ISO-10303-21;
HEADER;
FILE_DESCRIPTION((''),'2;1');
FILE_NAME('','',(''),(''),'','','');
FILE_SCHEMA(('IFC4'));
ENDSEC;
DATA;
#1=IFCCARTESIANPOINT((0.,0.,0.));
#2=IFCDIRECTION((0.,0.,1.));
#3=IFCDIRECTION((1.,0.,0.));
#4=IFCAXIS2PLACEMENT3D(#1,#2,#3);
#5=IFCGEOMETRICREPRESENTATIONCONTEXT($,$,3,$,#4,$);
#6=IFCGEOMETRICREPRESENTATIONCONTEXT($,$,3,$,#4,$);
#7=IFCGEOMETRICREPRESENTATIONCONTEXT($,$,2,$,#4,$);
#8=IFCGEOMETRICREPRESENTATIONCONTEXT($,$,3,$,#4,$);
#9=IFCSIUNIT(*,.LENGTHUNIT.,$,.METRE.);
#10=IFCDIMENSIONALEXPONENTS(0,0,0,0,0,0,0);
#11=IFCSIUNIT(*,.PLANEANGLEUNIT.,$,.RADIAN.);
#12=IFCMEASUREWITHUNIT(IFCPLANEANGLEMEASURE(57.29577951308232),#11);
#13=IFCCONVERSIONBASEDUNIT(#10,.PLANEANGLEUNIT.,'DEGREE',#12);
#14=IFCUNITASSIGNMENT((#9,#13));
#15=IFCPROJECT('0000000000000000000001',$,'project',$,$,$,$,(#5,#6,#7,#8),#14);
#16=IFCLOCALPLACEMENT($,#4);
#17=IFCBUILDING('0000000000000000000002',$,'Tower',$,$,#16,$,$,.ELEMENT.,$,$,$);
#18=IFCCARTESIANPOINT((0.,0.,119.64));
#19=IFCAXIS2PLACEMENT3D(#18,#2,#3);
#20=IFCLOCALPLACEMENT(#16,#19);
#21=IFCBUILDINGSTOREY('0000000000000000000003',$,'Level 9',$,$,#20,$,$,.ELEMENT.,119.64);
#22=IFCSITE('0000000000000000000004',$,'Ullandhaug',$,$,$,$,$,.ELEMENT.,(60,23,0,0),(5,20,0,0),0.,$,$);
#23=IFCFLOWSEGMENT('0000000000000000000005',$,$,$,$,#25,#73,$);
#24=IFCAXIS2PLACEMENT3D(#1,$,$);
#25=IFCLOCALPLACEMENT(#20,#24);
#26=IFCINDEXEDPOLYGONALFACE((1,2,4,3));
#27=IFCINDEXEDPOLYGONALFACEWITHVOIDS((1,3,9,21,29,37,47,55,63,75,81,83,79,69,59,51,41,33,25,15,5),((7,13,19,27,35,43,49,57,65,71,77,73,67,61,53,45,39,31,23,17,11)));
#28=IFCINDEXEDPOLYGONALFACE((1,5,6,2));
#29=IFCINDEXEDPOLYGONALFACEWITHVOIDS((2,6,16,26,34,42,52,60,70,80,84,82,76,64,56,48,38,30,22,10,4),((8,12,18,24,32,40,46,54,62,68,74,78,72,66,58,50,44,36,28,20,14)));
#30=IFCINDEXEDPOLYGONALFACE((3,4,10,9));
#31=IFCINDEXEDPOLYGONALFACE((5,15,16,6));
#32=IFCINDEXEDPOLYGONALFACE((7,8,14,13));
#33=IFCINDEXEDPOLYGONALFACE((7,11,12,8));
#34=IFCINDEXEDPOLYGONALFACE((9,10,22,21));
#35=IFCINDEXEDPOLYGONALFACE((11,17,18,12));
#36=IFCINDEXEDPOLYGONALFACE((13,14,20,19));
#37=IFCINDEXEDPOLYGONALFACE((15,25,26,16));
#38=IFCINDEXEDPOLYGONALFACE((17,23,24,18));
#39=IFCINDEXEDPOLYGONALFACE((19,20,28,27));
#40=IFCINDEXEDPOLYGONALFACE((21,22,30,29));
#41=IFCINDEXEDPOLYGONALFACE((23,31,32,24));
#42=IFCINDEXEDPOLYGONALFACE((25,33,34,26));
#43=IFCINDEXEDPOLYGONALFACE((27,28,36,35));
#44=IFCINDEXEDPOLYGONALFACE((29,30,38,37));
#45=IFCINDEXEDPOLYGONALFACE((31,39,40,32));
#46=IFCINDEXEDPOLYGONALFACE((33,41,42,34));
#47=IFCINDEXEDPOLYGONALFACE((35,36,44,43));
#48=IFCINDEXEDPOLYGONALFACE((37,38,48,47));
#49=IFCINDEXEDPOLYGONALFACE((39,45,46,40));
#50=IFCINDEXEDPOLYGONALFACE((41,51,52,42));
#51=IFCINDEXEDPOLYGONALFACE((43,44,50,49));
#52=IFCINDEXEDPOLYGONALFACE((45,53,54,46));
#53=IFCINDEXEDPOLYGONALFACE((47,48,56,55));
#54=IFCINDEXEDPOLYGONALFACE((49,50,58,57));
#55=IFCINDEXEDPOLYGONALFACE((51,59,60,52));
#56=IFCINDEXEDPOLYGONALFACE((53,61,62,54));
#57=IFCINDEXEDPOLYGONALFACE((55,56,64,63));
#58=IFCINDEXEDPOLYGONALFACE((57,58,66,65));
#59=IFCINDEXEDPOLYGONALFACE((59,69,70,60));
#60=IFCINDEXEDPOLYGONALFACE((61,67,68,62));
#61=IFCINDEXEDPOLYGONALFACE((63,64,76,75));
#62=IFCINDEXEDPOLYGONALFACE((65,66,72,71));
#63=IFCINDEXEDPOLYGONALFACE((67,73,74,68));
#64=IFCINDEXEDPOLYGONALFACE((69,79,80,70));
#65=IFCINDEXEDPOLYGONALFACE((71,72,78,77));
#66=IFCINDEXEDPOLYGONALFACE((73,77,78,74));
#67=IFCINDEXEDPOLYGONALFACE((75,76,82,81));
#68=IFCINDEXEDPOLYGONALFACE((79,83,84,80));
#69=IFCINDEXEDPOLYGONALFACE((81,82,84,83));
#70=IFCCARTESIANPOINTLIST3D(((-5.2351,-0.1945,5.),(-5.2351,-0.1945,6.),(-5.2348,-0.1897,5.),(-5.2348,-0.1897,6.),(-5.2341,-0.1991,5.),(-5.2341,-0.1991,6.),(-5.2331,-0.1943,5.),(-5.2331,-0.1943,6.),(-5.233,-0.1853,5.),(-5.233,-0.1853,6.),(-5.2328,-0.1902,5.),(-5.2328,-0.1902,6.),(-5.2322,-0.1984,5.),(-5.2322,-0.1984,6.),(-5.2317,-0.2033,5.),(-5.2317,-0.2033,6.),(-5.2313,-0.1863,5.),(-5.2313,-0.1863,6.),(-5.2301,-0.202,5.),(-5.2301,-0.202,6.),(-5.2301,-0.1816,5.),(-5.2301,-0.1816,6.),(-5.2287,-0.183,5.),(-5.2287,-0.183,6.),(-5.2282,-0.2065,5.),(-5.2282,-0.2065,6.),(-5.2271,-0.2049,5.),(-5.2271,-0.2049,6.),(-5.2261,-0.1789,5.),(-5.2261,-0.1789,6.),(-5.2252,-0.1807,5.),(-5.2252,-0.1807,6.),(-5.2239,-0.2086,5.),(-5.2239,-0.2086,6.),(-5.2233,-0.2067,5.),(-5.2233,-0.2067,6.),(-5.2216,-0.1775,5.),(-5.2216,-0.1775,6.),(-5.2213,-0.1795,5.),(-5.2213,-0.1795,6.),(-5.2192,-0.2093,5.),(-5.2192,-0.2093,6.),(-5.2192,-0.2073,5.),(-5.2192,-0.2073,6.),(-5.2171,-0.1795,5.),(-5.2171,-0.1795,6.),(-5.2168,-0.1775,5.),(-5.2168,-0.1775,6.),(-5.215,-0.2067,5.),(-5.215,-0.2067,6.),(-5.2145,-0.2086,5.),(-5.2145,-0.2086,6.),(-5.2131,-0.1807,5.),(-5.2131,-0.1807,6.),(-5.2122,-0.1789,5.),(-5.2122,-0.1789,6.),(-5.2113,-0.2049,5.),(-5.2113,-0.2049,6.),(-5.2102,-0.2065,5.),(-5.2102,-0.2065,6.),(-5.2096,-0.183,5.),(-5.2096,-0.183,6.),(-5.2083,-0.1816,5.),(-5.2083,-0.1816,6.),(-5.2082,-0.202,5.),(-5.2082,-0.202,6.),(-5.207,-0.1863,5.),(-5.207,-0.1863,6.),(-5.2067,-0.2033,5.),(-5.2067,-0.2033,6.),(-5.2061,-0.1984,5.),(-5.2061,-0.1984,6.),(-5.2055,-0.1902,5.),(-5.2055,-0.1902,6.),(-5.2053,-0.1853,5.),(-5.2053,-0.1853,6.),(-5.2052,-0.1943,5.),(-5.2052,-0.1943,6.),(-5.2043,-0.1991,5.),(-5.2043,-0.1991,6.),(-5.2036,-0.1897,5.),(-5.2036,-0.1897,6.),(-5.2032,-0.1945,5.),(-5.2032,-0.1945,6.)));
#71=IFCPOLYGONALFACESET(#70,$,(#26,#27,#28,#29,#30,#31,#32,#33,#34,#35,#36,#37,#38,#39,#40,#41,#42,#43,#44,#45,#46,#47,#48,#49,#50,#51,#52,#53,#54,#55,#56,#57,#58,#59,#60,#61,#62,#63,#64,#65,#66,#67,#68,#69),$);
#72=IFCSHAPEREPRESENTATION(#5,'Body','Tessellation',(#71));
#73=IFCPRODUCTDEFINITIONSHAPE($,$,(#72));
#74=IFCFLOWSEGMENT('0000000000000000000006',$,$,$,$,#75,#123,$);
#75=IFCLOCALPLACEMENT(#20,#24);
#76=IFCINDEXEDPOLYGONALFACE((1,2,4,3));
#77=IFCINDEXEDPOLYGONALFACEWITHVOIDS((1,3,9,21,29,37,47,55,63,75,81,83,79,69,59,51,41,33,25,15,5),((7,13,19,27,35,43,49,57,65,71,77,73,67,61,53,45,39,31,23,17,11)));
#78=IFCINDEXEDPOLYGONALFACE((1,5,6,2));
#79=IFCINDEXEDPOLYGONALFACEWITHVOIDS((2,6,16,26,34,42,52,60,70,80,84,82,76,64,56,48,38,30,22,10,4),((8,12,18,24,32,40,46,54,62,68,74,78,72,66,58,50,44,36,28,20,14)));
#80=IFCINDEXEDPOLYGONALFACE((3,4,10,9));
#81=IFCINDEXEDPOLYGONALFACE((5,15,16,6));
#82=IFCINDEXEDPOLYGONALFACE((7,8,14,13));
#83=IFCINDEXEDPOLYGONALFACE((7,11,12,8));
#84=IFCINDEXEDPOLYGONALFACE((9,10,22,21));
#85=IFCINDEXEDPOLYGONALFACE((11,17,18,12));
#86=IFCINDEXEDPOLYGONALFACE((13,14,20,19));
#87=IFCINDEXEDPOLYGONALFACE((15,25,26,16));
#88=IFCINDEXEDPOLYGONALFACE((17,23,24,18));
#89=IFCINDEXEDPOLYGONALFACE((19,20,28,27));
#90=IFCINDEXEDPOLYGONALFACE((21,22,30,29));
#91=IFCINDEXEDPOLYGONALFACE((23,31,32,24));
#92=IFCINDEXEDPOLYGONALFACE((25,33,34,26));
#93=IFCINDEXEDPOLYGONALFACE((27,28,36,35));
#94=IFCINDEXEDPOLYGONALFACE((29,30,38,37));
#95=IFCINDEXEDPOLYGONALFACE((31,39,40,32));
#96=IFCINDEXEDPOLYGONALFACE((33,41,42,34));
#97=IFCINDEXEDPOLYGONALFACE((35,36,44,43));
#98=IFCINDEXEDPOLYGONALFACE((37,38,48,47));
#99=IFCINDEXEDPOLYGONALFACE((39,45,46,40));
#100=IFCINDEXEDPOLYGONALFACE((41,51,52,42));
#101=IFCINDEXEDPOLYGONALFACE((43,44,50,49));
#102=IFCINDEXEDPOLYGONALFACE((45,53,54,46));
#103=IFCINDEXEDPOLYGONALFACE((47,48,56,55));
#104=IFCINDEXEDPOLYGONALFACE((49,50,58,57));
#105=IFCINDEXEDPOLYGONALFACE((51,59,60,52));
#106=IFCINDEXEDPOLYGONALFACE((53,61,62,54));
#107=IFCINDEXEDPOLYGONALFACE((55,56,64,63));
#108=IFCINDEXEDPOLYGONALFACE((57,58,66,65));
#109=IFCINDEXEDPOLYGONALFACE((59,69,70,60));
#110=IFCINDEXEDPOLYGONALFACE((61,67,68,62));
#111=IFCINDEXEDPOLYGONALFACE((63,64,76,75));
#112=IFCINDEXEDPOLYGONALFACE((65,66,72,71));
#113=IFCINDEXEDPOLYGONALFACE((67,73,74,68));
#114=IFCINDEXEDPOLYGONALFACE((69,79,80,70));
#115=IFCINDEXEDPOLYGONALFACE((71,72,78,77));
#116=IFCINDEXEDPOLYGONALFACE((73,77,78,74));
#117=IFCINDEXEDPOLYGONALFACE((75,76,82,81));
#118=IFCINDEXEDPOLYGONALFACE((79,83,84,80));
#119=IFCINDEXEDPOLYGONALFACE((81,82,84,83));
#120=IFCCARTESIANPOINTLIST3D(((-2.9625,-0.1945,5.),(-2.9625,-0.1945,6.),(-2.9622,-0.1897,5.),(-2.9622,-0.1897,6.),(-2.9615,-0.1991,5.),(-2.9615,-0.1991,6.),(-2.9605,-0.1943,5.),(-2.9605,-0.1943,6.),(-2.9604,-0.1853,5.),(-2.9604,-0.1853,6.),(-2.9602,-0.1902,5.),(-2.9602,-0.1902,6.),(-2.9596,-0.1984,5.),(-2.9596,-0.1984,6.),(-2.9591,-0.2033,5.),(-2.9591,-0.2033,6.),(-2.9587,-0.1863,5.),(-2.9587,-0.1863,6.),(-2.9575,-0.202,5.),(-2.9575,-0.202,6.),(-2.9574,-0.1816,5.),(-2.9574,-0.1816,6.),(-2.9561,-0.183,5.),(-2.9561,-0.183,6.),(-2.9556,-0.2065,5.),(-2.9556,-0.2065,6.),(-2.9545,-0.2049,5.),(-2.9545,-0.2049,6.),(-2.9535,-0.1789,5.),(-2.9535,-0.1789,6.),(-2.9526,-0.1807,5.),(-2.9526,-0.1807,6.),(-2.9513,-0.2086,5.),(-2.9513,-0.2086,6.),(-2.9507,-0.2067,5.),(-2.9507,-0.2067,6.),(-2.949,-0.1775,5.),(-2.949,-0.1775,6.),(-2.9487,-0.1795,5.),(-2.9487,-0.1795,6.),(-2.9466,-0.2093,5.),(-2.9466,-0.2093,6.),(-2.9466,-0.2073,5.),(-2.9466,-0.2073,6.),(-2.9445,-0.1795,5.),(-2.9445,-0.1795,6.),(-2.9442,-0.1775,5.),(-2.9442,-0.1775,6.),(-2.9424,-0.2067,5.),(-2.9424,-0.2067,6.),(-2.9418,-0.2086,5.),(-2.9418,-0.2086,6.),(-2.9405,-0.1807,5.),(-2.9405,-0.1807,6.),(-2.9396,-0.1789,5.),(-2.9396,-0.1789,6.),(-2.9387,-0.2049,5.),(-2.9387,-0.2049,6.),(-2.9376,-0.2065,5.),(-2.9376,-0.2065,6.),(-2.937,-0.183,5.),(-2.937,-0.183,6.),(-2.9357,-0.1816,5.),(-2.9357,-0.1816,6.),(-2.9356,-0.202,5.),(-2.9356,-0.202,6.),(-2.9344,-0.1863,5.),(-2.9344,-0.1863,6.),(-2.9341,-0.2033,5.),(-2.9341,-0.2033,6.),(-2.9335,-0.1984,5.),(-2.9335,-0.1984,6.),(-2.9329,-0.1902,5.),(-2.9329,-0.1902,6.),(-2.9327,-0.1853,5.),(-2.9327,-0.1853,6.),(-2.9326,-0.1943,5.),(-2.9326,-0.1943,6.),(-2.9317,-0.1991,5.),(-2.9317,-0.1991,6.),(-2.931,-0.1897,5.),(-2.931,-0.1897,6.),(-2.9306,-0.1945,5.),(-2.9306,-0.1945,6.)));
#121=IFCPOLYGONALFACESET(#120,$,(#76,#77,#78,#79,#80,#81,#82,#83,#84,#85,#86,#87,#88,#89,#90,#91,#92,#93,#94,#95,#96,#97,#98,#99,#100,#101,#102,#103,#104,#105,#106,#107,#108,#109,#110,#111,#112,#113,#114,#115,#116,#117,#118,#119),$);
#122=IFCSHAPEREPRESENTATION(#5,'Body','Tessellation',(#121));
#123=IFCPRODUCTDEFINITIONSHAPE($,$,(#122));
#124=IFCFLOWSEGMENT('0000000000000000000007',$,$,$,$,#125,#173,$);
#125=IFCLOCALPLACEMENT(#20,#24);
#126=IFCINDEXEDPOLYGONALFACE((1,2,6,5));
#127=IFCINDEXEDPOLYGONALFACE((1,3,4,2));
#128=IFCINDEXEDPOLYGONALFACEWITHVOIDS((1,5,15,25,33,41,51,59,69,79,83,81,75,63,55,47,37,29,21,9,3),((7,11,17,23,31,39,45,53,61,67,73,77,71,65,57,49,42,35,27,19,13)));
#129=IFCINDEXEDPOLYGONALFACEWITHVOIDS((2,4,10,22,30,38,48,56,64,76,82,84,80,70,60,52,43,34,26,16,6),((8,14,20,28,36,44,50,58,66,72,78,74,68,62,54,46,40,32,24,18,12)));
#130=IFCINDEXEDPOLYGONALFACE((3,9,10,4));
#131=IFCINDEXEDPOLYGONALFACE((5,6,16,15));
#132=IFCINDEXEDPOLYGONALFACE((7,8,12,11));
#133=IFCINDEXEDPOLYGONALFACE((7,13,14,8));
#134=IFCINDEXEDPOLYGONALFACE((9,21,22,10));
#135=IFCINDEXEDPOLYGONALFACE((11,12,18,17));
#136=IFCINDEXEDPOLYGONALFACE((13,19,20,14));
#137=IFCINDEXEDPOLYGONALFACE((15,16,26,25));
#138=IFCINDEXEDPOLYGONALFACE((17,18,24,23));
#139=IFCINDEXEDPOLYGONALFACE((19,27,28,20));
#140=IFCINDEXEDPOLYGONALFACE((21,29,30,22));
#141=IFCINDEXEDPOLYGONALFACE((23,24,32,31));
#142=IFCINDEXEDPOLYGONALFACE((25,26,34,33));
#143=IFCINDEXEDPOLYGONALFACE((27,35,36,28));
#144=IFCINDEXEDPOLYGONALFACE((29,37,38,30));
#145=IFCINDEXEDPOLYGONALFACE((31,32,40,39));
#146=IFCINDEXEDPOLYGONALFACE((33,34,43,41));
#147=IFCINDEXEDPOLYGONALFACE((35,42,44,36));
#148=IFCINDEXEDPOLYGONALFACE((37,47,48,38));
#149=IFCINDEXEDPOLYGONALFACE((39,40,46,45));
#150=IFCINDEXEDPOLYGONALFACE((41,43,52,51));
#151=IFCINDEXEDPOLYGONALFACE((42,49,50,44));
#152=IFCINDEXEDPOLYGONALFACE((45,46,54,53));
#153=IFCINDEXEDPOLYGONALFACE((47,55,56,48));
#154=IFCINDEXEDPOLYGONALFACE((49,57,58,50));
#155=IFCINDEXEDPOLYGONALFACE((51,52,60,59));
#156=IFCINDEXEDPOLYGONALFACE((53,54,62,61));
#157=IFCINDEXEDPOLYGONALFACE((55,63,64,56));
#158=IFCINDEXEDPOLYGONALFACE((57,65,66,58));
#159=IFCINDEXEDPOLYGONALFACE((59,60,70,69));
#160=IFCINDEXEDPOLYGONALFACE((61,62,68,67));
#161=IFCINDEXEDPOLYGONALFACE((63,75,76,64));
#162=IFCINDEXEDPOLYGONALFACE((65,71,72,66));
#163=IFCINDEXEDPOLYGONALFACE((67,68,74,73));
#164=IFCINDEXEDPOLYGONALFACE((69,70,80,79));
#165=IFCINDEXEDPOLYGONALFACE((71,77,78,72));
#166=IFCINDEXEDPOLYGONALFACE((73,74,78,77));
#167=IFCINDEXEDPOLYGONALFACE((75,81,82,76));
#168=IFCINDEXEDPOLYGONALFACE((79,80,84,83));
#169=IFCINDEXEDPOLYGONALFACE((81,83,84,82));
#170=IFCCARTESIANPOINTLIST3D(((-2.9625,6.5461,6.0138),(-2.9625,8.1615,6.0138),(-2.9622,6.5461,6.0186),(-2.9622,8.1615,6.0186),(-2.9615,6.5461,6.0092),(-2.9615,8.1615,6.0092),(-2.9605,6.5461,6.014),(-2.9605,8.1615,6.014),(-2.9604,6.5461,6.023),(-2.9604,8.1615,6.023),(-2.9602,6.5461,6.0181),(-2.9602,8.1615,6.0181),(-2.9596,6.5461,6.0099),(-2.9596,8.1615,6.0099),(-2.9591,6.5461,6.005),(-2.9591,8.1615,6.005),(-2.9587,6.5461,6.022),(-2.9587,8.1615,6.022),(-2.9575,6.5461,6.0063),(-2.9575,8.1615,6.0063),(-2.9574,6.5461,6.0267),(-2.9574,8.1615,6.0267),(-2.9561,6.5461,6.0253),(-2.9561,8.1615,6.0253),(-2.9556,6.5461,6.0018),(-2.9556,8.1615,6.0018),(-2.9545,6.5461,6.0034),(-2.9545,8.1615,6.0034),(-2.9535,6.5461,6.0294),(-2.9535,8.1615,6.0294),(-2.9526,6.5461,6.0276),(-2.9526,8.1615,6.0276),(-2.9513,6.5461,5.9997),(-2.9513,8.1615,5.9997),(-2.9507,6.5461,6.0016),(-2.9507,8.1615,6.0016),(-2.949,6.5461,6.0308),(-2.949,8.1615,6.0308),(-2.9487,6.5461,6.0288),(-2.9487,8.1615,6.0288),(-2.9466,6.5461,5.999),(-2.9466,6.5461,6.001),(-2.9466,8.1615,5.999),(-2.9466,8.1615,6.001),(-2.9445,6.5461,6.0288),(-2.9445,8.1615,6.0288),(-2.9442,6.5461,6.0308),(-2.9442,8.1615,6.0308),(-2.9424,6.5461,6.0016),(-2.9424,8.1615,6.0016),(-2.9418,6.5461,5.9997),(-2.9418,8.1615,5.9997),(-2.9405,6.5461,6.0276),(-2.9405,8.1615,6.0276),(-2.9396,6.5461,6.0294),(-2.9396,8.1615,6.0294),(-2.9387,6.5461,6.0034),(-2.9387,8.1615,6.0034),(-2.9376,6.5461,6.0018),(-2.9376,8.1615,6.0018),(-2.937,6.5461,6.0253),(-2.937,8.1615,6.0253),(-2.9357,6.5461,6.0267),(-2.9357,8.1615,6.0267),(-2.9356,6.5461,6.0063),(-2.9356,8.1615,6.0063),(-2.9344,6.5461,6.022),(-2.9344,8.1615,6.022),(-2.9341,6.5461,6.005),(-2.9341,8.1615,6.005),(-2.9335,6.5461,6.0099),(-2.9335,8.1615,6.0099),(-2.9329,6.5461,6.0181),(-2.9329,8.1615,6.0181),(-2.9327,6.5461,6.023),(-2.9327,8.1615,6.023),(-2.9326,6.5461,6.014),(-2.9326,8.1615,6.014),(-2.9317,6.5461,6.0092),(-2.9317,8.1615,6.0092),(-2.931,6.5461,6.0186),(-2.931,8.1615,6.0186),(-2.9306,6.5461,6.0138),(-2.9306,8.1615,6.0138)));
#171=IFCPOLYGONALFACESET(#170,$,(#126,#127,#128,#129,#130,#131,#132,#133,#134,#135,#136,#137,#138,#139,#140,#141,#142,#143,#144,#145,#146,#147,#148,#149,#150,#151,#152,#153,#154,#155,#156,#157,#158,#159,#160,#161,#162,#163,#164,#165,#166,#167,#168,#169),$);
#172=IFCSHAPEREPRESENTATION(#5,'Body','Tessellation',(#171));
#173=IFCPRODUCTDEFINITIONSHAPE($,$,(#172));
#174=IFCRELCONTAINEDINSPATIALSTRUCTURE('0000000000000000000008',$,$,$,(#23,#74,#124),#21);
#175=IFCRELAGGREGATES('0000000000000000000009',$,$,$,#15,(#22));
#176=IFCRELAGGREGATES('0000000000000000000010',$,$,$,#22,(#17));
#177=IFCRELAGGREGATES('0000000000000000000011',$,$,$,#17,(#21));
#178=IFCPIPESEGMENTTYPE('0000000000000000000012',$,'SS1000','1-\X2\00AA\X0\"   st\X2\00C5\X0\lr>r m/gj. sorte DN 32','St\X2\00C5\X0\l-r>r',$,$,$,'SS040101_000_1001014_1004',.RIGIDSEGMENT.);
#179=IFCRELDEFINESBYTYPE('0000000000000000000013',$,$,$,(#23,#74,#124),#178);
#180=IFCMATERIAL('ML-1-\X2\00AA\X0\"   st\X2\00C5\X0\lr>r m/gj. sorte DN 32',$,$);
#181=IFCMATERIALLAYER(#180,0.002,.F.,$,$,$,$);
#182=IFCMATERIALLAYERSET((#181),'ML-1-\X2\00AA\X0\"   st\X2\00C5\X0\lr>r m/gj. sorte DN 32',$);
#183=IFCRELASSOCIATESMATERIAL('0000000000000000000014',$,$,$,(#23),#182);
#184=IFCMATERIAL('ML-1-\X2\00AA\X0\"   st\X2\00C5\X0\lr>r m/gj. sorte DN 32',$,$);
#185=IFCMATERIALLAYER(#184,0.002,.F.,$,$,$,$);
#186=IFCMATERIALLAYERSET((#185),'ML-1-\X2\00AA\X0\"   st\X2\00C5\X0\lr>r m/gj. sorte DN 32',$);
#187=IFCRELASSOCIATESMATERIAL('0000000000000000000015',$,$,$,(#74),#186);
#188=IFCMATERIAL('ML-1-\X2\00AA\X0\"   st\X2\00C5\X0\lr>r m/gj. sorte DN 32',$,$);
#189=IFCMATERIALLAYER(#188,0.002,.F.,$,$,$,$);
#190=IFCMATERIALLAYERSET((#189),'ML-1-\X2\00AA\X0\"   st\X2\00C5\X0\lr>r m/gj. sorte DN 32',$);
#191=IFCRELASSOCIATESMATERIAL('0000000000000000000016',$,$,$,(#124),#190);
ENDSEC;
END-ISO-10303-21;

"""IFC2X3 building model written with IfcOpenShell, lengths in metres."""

from ifc_helpers import new_model, entity, si_unit, converted_unit, frame, origin_with_axes, origin_2d_with_axis, place, context, project, spatial, hollow_circle, extrude, material, layer, layer_set, layer_usage, type_object, element, save


model = new_model("IFC2X3")

# Units and contexts
context_of_model_1 = context(None, 3, world=origin_with_axes())
context_of_model_2 = context(None, 3, world=origin_with_axes())
context_of_model_3 = context(None, 2, world=origin_with_axes())
context_of_model_4 = context(None, 3, world=origin_with_axes())
ifc_project = project(units=[si_unit("LENGTHUNIT", "METRE"), converted_unit("PLANEANGLEUNIT", "DEGREE", entity("IfcPlaneAngleMeasure", 57.29577951308232), si_unit("PLANEANGLEUNIT", "RADIAN"), dimensions=[0, 0, 0, 0, 0, 0, 0])], contexts=[context_of_model_1, context_of_model_2, context_of_model_3, context_of_model_4])

# Site, building, storey
site = spatial("IfcSite", under=ifc_project, Name="Ullandhaug", CompositionType="ELEMENT", RefLatitude=(60, 23, 0, 0), RefLongitude=(5, 20, 0, 0), RefElevation=0.0)
building_placement = place(None, origin_with_axes())
building = spatial("IfcBuilding", under=site, at=building_placement, Name="Tower", CompositionType="ELEMENT")
storey_placement = place(building_placement, frame((0.0, 0.0, 119.64), z_axis=(0.0, 0.0, 1.0), x_axis=(1.0, 0.0, 0.0)))
storey = spatial("IfcBuildingStorey", under=building, at=storey_placement, Name="Level 9", CompositionType="ELEMENT", Elevation=119.64)

# Flow segments
pipe_segment_type_1 = type_object("IfcPipeSegmentType", Name="SS1000", Description="1-ª\"   stÅlr>r m/gj. sorte DN 32", ApplicableOccurrence="StÅl-r>r", ElementType="SS040101_000_1001014_1004", PredefinedType="RIGIDSEGMENT")
ifc_material_1 = material(Name="ML-1-ª\"   stÅlr>r m/gj. sorte DN 32")
ifc_layer_1 = layer(ifc_material_1, 0.002, ventilated=False)
ifc_layer_set_1 = layer_set([ifc_layer_1], Name="ML-1-ª\"   stÅlr>r m/gj. sorte DN 32")
ifc_layer_usage_1 = layer_usage(ifc_layer_set_1, "AXIS2", "POSITIVE", 0.0)
flow_segment_1_placement = place(storey_placement, frame((-5.2192, -0.1933, 5.0), z_axis=(0.0, 0.0, 1.0), x_axis=(0.0, -1.0, 0.0)))
element("IfcFlowSegment", 1, at=flow_segment_1_placement, inside=storey, type_object=pipe_segment_type_1, material=ifc_layer_usage_1, context=context_of_model_1, shape_type="SweptSolid", body=[
    extrude(hollow_circle(Radius=0.016, WallThickness=0.002, at=origin_2d_with_axis()), origin_with_axes(), (0.0, 0.0, 1.0), 1.0),
])
ifc_material_2 = material(Name="ML-1-ª\"   stÅlr>r m/gj. sorte DN 32")
ifc_layer_2 = layer(ifc_material_2, 0.002, ventilated=False)
ifc_layer_set_2 = layer_set([ifc_layer_2], Name="ML-1-ª\"   stÅlr>r m/gj. sorte DN 32")
ifc_layer_usage_2 = layer_usage(ifc_layer_set_2, "AXIS2", "POSITIVE", 0.0)
flow_segment_2_placement = place(storey_placement, frame((-2.9466, -0.1933, 5.0), z_axis=(0.0, 0.0, 1.0), x_axis=(0.0, -1.0, 0.0)))
element("IfcFlowSegment", 2, at=flow_segment_2_placement, inside=storey, type_object=pipe_segment_type_1, material=ifc_layer_usage_2, context=context_of_model_1, shape_type="SweptSolid", body=[
    extrude(hollow_circle(Radius=0.016, WallThickness=0.002, at=origin_2d_with_axis()), origin_with_axes(), (0.0, 0.0, 1.0), 1.0),
])
ifc_material_3 = material(Name="ML-1-ª\"   stÅlr>r m/gj. sorte DN 32")
ifc_layer_3 = layer(ifc_material_3, 0.002, ventilated=False)
ifc_layer_set_3 = layer_set([ifc_layer_3], Name="ML-1-ª\"   stÅlr>r m/gj. sorte DN 32")
ifc_layer_usage_3 = layer_usage(ifc_layer_set_3, "AXIS2", "POSITIVE", 0.0)
flow_segment_3_placement = place(storey_placement, frame((-2.9466, 6.5461, 6.015), z_axis=(0.0, 1.0, 0.0), x_axis=(0.0, 0.0, -1.0)))
element("IfcFlowSegment", 3, at=flow_segment_3_placement, inside=storey, type_object=pipe_segment_type_1, material=ifc_layer_usage_3, context=context_of_model_1, shape_type="SweptSolid", body=[
    extrude(hollow_circle(Radius=0.016, WallThickness=0.002, at=origin_2d_with_axis()), origin_with_axes(), (0.0, 0.0, 1.0), 1.6154),
])

save(model, "model.ifc")
